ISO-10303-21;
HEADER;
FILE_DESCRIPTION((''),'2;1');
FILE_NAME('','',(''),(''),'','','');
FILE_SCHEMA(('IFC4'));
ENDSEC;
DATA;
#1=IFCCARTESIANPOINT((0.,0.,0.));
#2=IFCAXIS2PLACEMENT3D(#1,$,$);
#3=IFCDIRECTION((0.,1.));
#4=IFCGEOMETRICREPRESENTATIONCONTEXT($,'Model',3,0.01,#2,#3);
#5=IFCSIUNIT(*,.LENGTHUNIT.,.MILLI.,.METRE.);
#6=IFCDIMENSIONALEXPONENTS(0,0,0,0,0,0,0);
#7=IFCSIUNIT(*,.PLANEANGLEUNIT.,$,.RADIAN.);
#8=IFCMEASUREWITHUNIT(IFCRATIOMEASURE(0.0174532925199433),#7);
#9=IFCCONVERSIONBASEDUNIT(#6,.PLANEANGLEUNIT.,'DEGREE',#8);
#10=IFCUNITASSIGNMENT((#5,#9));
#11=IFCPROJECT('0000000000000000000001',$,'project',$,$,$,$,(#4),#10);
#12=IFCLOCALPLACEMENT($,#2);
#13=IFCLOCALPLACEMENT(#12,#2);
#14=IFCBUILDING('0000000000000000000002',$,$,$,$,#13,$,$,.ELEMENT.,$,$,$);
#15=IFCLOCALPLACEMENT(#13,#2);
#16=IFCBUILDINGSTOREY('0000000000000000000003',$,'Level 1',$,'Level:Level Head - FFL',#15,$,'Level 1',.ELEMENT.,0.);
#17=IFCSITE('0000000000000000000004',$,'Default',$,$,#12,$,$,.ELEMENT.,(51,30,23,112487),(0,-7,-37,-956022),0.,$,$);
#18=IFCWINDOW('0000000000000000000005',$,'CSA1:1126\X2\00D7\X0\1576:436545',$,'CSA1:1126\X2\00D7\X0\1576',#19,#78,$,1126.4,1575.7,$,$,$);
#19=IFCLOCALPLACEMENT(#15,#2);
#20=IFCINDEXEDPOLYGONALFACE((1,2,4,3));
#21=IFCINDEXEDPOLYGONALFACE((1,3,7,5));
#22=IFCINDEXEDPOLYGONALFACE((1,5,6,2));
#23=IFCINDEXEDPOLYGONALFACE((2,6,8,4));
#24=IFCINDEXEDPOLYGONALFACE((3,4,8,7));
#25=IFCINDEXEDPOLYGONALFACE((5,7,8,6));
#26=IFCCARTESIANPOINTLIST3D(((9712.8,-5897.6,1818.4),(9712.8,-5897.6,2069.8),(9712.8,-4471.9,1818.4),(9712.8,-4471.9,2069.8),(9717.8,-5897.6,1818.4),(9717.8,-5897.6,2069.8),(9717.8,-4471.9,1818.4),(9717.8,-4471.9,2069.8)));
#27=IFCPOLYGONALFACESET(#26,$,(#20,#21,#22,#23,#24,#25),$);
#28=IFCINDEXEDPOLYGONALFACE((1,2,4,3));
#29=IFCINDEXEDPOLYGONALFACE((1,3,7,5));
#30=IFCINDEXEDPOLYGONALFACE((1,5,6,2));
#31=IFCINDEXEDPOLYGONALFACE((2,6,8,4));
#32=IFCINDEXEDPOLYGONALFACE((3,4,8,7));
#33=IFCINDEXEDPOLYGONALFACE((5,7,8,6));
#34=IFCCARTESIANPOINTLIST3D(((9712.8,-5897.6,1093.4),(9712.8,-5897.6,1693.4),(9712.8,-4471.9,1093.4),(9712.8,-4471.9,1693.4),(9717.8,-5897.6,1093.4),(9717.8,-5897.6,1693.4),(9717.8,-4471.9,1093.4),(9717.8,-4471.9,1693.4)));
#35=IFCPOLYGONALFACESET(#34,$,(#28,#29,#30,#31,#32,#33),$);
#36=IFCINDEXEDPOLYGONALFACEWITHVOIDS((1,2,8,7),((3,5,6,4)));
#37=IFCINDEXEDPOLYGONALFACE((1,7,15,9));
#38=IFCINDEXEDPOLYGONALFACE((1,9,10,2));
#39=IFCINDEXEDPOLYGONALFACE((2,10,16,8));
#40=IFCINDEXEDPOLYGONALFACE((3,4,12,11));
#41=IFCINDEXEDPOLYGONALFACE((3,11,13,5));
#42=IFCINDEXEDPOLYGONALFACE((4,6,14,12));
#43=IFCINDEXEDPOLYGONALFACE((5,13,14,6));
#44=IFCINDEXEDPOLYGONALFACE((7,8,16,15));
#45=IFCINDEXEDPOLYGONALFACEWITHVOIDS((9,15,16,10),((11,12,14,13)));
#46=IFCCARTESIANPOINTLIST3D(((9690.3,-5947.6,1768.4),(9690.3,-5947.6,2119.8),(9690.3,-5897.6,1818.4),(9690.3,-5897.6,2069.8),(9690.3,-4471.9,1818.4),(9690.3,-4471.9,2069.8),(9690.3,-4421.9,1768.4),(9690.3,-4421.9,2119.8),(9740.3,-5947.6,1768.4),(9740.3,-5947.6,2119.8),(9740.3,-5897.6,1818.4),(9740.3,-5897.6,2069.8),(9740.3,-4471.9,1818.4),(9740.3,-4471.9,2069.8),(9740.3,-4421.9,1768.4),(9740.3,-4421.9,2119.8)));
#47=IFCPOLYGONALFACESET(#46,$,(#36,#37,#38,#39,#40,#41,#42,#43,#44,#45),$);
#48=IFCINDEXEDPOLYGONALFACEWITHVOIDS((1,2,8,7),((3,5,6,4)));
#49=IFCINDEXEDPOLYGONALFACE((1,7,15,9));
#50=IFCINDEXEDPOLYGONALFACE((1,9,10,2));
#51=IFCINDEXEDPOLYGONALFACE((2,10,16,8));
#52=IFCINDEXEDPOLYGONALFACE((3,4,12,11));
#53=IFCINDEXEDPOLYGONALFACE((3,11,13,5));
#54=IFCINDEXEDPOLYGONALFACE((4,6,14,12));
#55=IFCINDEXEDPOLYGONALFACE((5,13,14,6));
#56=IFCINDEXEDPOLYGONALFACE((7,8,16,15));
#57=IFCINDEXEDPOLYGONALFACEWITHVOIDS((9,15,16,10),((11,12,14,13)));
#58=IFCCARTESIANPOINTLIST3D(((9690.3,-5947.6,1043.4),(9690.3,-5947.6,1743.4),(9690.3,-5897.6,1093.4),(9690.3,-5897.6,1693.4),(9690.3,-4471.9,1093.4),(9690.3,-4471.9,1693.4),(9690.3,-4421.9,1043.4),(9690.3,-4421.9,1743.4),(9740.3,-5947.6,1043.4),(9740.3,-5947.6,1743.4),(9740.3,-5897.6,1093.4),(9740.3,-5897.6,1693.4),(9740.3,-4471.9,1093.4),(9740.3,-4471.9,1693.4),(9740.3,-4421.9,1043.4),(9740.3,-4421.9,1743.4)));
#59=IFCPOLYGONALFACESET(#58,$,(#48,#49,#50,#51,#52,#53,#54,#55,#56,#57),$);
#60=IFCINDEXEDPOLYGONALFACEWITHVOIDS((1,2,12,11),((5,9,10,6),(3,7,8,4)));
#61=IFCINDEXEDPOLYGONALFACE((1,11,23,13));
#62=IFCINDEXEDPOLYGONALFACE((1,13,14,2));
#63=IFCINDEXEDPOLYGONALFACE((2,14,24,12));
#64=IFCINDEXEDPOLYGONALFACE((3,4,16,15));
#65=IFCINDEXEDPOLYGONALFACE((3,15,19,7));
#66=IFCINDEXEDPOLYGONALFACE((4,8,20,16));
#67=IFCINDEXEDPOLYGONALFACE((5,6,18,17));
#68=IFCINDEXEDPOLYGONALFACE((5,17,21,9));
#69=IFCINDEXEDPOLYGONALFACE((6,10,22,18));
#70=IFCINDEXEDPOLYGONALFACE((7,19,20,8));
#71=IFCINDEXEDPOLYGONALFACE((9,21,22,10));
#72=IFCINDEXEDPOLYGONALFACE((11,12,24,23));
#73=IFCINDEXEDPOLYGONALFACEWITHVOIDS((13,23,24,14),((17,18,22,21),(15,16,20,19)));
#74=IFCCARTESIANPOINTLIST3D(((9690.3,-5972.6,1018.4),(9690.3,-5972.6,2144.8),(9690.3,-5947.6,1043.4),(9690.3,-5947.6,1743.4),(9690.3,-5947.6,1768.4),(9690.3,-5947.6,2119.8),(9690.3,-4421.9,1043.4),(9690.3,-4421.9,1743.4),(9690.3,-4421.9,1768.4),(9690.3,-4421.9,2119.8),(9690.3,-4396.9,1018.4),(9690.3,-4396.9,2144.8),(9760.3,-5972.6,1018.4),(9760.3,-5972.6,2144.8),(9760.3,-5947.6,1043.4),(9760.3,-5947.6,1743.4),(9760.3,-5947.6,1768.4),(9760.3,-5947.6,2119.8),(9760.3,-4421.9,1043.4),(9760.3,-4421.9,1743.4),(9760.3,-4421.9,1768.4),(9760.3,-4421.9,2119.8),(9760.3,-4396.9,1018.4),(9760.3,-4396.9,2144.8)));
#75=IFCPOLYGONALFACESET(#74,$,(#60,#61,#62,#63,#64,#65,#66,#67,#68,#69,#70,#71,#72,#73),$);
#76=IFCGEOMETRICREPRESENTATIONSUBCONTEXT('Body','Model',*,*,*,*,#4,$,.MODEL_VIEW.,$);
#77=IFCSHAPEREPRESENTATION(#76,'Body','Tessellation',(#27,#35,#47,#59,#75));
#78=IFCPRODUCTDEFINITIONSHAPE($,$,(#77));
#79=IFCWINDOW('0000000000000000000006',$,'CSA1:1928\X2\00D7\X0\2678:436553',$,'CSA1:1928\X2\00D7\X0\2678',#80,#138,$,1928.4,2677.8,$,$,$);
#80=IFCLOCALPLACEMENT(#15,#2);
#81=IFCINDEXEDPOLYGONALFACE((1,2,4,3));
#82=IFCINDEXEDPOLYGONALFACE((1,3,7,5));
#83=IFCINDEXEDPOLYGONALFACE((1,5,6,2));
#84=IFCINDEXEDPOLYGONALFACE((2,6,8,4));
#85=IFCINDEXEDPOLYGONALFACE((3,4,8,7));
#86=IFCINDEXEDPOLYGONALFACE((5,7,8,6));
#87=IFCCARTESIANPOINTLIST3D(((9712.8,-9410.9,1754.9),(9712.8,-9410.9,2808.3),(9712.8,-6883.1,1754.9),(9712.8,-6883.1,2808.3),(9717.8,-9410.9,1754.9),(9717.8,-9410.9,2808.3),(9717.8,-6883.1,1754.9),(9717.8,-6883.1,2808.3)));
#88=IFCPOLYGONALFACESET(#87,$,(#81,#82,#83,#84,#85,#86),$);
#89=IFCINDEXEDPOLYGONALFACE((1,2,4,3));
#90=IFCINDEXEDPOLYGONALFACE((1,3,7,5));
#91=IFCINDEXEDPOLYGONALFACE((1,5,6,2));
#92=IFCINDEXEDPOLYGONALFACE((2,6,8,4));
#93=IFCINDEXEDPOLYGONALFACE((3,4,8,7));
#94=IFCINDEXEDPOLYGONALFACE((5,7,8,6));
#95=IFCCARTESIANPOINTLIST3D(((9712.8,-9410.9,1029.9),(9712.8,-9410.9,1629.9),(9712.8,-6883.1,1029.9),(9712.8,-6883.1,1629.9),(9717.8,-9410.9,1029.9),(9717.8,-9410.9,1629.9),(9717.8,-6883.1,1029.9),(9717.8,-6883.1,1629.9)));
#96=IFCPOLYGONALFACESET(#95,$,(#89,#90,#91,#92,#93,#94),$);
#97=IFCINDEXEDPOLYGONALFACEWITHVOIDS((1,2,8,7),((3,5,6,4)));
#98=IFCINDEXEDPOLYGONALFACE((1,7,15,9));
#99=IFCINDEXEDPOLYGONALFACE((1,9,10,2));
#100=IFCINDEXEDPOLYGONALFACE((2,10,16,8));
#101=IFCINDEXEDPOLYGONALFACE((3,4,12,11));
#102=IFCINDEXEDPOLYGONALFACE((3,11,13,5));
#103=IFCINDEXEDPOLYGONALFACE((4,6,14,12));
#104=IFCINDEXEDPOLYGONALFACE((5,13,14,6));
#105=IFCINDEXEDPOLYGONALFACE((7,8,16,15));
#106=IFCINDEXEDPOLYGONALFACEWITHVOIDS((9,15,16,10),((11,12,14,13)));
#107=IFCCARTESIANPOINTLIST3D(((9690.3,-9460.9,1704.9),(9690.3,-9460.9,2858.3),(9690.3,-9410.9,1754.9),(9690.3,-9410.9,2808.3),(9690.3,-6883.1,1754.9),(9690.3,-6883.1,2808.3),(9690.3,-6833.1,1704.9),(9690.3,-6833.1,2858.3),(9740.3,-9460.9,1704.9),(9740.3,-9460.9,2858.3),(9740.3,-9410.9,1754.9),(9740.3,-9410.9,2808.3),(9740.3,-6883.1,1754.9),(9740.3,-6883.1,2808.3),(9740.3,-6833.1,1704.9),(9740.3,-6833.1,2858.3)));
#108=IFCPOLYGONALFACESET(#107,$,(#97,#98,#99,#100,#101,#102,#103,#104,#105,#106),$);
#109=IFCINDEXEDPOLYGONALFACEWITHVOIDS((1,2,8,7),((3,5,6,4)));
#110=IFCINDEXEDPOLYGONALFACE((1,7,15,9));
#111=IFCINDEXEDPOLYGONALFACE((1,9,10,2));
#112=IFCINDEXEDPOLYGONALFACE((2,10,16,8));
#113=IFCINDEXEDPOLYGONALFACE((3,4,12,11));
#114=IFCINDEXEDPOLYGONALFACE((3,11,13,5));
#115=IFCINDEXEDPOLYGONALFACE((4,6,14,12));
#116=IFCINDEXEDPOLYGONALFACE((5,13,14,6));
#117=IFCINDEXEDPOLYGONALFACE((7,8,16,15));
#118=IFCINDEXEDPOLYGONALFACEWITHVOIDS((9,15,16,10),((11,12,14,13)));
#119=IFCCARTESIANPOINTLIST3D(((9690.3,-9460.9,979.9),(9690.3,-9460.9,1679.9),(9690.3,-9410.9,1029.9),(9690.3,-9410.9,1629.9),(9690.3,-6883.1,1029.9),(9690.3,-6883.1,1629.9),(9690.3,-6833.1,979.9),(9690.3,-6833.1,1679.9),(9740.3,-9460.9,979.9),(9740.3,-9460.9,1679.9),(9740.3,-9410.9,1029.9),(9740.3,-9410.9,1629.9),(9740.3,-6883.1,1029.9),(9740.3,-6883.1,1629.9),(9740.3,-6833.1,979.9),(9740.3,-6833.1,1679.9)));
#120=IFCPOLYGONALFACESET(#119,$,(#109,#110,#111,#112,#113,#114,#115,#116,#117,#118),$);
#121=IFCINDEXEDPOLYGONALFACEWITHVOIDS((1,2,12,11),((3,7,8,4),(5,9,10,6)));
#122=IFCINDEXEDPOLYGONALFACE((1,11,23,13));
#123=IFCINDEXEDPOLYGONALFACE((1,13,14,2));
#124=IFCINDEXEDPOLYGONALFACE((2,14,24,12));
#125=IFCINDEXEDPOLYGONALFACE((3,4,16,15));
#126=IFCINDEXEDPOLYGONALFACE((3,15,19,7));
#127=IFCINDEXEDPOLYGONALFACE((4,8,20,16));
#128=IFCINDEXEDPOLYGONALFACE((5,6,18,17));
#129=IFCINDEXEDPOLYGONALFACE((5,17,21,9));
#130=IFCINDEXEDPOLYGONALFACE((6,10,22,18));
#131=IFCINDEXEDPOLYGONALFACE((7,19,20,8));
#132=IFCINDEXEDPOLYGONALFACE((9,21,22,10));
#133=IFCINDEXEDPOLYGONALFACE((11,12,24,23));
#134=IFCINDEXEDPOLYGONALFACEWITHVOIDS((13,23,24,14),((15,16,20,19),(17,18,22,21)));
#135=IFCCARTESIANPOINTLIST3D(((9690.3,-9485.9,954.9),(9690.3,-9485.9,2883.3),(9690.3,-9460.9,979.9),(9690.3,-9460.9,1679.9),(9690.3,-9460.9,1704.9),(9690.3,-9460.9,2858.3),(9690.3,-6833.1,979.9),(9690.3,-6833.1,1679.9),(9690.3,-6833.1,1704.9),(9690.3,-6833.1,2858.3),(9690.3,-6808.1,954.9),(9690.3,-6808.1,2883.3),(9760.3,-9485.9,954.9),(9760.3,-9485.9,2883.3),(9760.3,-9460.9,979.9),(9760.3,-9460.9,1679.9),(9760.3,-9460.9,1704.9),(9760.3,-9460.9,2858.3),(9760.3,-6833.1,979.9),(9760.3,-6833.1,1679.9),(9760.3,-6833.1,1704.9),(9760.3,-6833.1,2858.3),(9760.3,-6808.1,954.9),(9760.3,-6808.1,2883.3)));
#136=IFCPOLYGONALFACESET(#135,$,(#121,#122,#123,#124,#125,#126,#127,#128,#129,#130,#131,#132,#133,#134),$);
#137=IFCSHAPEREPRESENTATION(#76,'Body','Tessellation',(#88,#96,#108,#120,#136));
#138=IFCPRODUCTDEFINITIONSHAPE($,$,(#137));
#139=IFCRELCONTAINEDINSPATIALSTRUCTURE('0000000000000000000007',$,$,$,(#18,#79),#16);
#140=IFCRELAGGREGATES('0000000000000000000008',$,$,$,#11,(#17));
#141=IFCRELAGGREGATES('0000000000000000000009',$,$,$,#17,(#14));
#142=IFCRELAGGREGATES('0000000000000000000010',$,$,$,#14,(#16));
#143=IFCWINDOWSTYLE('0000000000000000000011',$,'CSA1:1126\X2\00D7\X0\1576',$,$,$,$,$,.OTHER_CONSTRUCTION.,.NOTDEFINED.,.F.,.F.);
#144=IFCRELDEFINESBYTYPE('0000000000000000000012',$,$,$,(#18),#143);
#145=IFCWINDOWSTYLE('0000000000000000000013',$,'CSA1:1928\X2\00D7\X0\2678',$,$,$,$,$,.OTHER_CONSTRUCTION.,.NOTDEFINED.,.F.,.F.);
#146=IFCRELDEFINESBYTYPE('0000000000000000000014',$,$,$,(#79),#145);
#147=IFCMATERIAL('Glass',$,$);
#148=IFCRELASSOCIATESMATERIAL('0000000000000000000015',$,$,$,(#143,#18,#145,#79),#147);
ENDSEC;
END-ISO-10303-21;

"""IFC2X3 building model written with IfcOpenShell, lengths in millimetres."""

from ifc_helpers import new_model, entity, si_unit, converted_unit, direction, frame, origin, origin_2d_with_axis, place, context, subcontext, project, spatial, polyline, rectangle, outline, extrude, source, transform, mapped, material, type_object, type_shapes, element, save


model = new_model("IFC2X3")

# Units and contexts
model_context = context("Model", 3, precision=0.01, world=origin(), true_north=direction((0.0, 1.0)))
body_context = subcontext(model_context, "Body", "Model", "MODEL_VIEW")
ifc_project = project(units=[si_unit("LENGTHUNIT", "METRE", prefix="MILLI"), converted_unit("PLANEANGLEUNIT", "DEGREE", entity("IfcRatioMeasure", 0.0174532925199433), si_unit("PLANEANGLEUNIT", "RADIAN"), dimensions=[0, 0, 0, 0, 0, 0, 0])], contexts=[model_context])

# Site, building, storey
site_placement = place(None, origin())
site = spatial("IfcSite", under=ifc_project, at=site_placement, Name="Default", CompositionType="ELEMENT", RefLatitude=(51, 30, 23, 112487), RefLongitude=(0, -7, -37, -956022), RefElevation=0.0)
building_placement = place(site_placement, origin())
building = spatial("IfcBuilding", under=site, at=building_placement, CompositionType="ELEMENT")
storey_placement = place(building_placement, origin())
storey = spatial("IfcBuildingStorey", under=building, at=storey_placement, Name="Level 1", ObjectType="Level:Level Head - FFL", LongName="Level 1", CompositionType="ELEMENT", Elevation=0.0)

# Windows
ifc_material_1 = material(Name="Glass")
window_style_1 = type_object("IfcWindowStyle", Name="CSA1:1126×1576", ConstructionType="OTHER_CONSTRUCTION", OperationType="NOTDEFINED", ParameterTakesPrecedence=False, Sizeable=False, material=ifc_material_1)
shared_shape_1 = source(origin(), body_context, "Body", "SweptSolid", [
    extrude(rectangle(XDim=5.0, YDim=1425.7, at=origin_2d_with_axis()), frame((787.9, 45.0, 800.0), z_axis=(0.0, 0.0, 1.0), x_axis=(0.0, 1.0, 0.0)), (0.0, 0.0, 1.0), 251.4),
    extrude(rectangle(XDim=5.0, YDim=1425.7, at=origin_2d_with_axis()), frame((787.9, 45.0, 75.0), z_axis=(0.0, 0.0, 1.0), x_axis=(0.0, 1.0, 0.0)), (0.0, 0.0, 1.0), 600.0),
    extrude(outline(polyline([(-762.9, -175.7), (762.9, -175.7), (762.9, 175.7), (-762.9, 175.7), (-762.9, -175.7)]), holes=[polyline([(-712.9, -125.7), (-712.9, 125.7), (712.9, 125.7), (712.9, -125.7), (-712.9, -125.7)])]), frame((787.9, 20.0, 925.7), z_axis=(0.0, 1.0, 0.0), x_axis=(1.0, 0.0, 0.0)), (0.0, 0.0, 1.0), 50.0),
    extrude(outline(polyline([(-762.9, -350.0), (762.9, -350.0), (762.9, 350.0), (-762.9, 350.0), (-762.9, -350.0)]), holes=[polyline([(-712.9, -300.0), (-712.9, 300.0), (712.9, 300.0), (712.9, -300.0), (-712.9, -300.0)])]), frame((787.9, 20.0, 375.0), z_axis=(0.0, 1.0, 0.0), x_axis=(1.0, 0.0, 0.0)), (0.0, 0.0, 1.0), 50.0),
    extrude(outline(polyline([(-787.9, -563.2), (787.9, -563.2), (787.9, 563.2), (-787.9, 563.2), (-787.9, -563.2)]), holes=[polyline([(-762.9, -538.2), (-762.9, -186.8), (762.9, -186.8), (762.9, -538.2), (-762.9, -538.2)]), polyline([(-762.9, -161.8), (-762.9, 538.2), (762.9, 538.2), (762.9, -161.8), (-762.9, -161.8)])]), frame((787.9, 0.0, 563.2), z_axis=(0.0, 1.0, 0.0), x_axis=(1.0, 0.0, 0.0)), (0.0, 0.0, 1.0), 70.0),
])
type_shapes(window_style_1, [shared_shape_1])
window_1_placement = place(storey_placement, frame((9760.3, -5972.6, 1018.4), z_axis=(0.0, 0.0, 1.0), x_axis=(0.0, 1.0, 0.0)))
element("IfcWindow", 1, at=window_1_placement, inside=storey, type_object=window_style_1, material=ifc_material_1, Name="CSA1:1126×1576:436545", ObjectType="CSA1:1126×1576", OverallHeight=1126.4, OverallWidth=1575.7, context=body_context, shape_type="MappedRepresentation", body=[
    mapped(shared_shape_1, transform((0.0, 0.0, 0.0), scale=1.0)),
])
window_style_2 = type_object("IfcWindowStyle", Name="CSA1:1928×2678", ConstructionType="OTHER_CONSTRUCTION", OperationType="NOTDEFINED", ParameterTakesPrecedence=False, Sizeable=False, material=ifc_material_1)
shared_shape_2 = source(origin(), body_context, "Body", "SweptSolid", [
    extrude(rectangle(XDim=5.0, YDim=2527.8, at=origin_2d_with_axis()), frame((1338.9, 45.0, 800.0), z_axis=(0.0, 0.0, 1.0), x_axis=(0.0, 1.0, 0.0)), (0.0, 0.0, 1.0), 1053.4),
    extrude(rectangle(XDim=5.0, YDim=2527.8, at=origin_2d_with_axis()), frame((1338.9, 45.0, 75.0), z_axis=(0.0, 0.0, 1.0), x_axis=(0.0, 1.0, 0.0)), (0.0, 0.0, 1.0), 600.0),
    extrude(outline(polyline([(-1313.9, -576.7), (1313.9, -576.7), (1313.9, 576.7), (-1313.9, 576.7), (-1313.9, -576.7)]), holes=[polyline([(-1263.9, -526.7), (-1263.9, 526.7), (1263.9, 526.7), (1263.9, -526.7), (-1263.9, -526.7)])]), frame((1338.9, 20.0, 1326.7), z_axis=(0.0, 1.0, 0.0), x_axis=(1.0, 0.0, 0.0)), (0.0, 0.0, 1.0), 50.0),
    extrude(outline(polyline([(-1313.9, -350.0), (1313.9, -350.0), (1313.9, 350.0), (-1313.9, 350.0), (-1313.9, -350.0)]), holes=[polyline([(-1263.9, -300.0), (-1263.9, 300.0), (1263.9, 300.0), (1263.9, -300.0), (-1263.9, -300.0)])]), frame((1338.9, 20.0, 375.0), z_axis=(0.0, 1.0, 0.0), x_axis=(1.0, 0.0, 0.0)), (0.0, 0.0, 1.0), 50.0),
    extrude(outline(polyline([(-1338.9, -964.2), (1338.9, -964.2), (1338.9, 964.2), (-1338.9, 964.2), (-1338.9, -964.2)]), holes=[polyline([(-1313.9, -939.2), (-1313.9, 214.2), (1313.9, 214.2), (1313.9, -939.2), (-1313.9, -939.2)]), polyline([(-1313.9, 239.2), (-1313.9, 939.2), (1313.9, 939.2), (1313.9, 239.2), (-1313.9, 239.2)])]), frame((1338.9, 0.0, 964.2), z_axis=(0.0, 1.0, 0.0), x_axis=(1.0, 0.0, 0.0)), (0.0, 0.0, 1.0), 70.0),
])
type_shapes(window_style_2, [shared_shape_2])
window_2_placement = place(storey_placement, frame((9760.3, -9485.9, 954.9), z_axis=(0.0, 0.0, 1.0), x_axis=(0.0, 1.0, 0.0)))
element("IfcWindow", 2, at=window_2_placement, inside=storey, type_object=window_style_2, material=ifc_material_1, Name="CSA1:1928×2678:436553", ObjectType="CSA1:1928×2678", OverallHeight=1928.4, OverallWidth=2677.8, context=body_context, shape_type="MappedRepresentation", body=[
    mapped(shared_shape_2, transform((0.0, 0.0, 0.0), scale=1.0)),
])

save(model, "model.ifc")
